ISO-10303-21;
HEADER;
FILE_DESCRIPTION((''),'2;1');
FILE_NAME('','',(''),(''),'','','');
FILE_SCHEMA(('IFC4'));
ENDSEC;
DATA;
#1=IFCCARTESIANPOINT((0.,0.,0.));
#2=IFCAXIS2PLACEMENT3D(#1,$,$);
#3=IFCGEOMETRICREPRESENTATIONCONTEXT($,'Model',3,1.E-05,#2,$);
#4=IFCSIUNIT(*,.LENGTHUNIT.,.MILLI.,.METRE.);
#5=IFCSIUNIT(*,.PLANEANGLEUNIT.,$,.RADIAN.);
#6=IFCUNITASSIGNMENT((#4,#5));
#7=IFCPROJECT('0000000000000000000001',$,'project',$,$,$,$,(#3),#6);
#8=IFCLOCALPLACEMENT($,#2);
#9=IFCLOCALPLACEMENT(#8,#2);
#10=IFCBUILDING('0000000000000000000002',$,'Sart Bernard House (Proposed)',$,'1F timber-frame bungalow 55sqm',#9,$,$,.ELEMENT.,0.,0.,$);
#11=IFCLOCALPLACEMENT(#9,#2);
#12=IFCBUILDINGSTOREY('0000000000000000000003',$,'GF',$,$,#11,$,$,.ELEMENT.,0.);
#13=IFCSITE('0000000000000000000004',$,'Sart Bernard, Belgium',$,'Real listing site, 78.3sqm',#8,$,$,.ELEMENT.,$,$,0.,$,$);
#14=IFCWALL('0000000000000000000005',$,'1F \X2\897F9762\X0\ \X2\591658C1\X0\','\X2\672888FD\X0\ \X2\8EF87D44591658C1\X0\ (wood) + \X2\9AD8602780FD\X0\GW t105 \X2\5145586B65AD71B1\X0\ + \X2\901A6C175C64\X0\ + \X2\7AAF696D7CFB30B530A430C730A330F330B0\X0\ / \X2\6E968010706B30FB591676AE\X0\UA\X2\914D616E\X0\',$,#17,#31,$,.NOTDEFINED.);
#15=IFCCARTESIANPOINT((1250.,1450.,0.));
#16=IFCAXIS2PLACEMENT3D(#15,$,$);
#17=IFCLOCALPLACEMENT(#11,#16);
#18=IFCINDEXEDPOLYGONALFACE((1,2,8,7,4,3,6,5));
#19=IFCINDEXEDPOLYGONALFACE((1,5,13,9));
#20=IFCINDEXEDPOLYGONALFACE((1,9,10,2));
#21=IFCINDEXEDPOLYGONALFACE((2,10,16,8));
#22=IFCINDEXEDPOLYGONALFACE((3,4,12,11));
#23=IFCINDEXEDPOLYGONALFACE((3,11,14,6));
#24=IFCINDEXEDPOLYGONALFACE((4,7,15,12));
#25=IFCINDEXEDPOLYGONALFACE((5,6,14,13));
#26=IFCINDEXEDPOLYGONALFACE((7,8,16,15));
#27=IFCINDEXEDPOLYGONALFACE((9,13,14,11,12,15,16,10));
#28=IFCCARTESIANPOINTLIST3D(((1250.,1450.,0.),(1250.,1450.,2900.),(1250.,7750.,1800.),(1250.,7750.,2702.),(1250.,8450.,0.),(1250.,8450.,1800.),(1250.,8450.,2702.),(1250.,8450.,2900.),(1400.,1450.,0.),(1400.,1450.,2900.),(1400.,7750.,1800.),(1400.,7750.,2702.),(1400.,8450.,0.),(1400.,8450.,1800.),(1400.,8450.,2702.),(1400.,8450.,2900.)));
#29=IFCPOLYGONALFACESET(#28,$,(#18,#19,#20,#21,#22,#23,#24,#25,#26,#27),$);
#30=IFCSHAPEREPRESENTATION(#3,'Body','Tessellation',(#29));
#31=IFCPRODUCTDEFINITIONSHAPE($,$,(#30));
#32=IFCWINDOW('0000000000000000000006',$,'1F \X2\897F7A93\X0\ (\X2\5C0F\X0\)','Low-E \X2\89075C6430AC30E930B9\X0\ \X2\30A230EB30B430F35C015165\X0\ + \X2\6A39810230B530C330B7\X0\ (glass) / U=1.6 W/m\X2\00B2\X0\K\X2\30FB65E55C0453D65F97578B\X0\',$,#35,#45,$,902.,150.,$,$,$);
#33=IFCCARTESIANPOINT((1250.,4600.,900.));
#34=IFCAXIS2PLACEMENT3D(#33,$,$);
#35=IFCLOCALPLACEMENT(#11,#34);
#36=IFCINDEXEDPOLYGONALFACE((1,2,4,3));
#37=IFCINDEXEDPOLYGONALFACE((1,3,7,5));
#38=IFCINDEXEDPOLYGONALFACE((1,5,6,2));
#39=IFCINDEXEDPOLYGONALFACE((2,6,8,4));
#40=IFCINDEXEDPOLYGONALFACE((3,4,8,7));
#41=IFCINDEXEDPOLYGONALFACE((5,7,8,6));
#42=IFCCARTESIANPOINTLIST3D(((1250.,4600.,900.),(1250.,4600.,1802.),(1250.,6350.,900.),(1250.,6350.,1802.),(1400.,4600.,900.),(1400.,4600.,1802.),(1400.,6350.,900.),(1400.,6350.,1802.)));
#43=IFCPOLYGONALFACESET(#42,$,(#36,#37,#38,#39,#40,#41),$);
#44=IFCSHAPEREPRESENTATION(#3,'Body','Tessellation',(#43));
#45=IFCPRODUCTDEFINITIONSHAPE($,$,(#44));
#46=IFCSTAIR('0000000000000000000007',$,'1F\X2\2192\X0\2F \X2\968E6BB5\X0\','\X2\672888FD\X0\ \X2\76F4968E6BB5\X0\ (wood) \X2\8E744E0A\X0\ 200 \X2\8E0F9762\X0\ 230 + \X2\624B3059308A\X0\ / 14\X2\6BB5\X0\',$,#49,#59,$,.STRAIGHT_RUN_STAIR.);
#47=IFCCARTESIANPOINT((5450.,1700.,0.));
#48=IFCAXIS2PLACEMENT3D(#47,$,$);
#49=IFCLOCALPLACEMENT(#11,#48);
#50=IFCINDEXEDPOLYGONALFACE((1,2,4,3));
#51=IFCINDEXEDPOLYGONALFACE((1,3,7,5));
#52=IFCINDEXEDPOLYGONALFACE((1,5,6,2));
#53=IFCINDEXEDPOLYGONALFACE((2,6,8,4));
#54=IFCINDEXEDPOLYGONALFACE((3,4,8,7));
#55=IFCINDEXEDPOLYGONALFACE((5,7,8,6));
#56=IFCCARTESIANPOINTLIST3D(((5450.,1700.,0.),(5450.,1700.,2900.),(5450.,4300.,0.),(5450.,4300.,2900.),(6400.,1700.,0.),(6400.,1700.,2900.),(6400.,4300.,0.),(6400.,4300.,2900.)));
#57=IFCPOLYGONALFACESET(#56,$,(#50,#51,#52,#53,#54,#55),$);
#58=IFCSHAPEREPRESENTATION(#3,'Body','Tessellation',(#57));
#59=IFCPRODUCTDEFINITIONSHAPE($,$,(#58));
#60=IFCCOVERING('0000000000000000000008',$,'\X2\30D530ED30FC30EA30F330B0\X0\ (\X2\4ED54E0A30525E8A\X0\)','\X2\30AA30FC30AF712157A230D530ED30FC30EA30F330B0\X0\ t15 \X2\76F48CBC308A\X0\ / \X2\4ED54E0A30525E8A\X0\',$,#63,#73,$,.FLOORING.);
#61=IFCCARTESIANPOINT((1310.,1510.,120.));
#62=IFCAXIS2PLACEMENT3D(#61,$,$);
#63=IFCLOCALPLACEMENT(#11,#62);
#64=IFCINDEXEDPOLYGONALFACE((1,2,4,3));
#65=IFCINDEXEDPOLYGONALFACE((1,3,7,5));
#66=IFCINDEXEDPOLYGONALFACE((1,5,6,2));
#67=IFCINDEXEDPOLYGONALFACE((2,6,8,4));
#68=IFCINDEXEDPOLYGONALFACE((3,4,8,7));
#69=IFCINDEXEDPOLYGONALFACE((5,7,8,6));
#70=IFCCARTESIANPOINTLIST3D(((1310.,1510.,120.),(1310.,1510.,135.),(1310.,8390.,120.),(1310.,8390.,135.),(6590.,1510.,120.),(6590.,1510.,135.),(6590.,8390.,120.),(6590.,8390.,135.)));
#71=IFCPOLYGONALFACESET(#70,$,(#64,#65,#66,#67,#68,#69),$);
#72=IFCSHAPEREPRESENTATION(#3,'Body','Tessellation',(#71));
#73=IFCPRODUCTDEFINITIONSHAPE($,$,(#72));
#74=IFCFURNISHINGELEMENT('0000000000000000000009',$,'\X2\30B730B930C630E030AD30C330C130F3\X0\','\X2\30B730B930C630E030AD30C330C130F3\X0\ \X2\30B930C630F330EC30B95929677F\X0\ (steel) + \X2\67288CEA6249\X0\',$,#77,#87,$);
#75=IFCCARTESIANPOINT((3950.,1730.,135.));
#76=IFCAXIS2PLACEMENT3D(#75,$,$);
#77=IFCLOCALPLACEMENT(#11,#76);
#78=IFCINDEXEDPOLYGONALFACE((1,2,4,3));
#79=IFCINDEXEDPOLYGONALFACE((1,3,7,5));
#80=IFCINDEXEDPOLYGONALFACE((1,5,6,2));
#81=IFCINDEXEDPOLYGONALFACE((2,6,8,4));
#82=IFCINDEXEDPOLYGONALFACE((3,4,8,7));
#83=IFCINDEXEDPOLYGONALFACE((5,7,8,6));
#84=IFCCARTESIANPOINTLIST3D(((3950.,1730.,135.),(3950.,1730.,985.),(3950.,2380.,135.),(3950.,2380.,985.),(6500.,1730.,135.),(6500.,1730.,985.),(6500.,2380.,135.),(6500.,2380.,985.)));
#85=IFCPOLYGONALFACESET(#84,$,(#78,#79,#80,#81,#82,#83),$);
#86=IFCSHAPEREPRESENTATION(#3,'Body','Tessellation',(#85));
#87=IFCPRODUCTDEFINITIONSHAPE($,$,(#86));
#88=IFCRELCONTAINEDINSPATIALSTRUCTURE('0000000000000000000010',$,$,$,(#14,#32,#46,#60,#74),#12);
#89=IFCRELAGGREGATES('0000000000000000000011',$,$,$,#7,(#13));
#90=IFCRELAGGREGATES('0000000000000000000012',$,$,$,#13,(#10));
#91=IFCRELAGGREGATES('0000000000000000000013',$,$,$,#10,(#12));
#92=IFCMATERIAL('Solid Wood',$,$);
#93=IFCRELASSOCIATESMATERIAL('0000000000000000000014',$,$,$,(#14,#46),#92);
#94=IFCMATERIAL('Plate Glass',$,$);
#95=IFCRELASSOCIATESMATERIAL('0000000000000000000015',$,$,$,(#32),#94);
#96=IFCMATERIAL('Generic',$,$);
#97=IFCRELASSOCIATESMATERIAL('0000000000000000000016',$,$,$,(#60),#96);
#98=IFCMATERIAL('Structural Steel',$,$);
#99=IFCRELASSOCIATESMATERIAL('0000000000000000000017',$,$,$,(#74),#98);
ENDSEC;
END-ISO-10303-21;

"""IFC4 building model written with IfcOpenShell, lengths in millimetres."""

from ifc_helpers import new_model, si_unit, frame, frame_2d, origin, place, context, project, spatial, rectangle, extrude, material, element, fill, save


model = new_model("IFC4")

# Units and contexts
model_context = context("Model", 3, precision=1e-05, world=origin())
ifc_project = project(units=[si_unit("LENGTHUNIT", "METRE", prefix="MILLI"), si_unit("PLANEANGLEUNIT", "RADIAN")], contexts=[model_context])

# Site, building, storey
site_placement = place(None, origin())
site = spatial("IfcSite", under=ifc_project, at=site_placement, Name="Sart Bernard, Belgium", ObjectType="Real listing site, 78.3sqm", CompositionType="ELEMENT", RefElevation=0.0)
building_placement = place(site_placement, origin())
building = spatial("IfcBuilding", under=site, at=building_placement, Name="Sart Bernard House (Proposed)", ObjectType="1F timber-frame bungalow 55sqm", CompositionType="ELEMENT", ElevationOfRefHeight=0.0, ElevationOfTerrain=0.0)
storey_placement = place(building_placement, origin())
storey = spatial("IfcBuildingStorey", under=building, at=storey_placement, Name="GF", CompositionType="ELEMENT", Elevation=0.0)

# Shared definitions
ifc_material_1 = material(Name="Solid Wood")
ifc_material_2 = material(Name="Generic")

# Shared definitions
ifc_material_3 = material(Name="Plate Glass")

# Wall, opening, window
wall_1_placement = place(storey_placement, frame((1250.0, 1450.0, 0.0)))
wall_1 = element("IfcWall", 1, at=wall_1_placement, inside=storey, material=ifc_material_1, Name="1F 西面 外壁", Description="木製 軸組外壁 (wood) + 高性能GW t105 充填断熱 + 通気層 + 窯業系サイディング / 準耐火・外皮UA配慮", PredefinedType="NOTDEFINED", context=model_context, shape_type="SweptSolid", body=[
    extrude(rectangle(XDim=150.0, YDim=7000.0, at=frame_2d((75.0, 3500.0))), frame((1250.0, 1450.0, 0.0)), (0.0, 0.0, 1.0), 2900.0),
])
opening_1_placement = place(storey_placement, frame((1250.0, 4600.0, 900.0)))
opening_1 = element("IfcOpeningElement", 2, at=opening_1_placement, cuts=wall_1, PredefinedType="NOTDEFINED", context=model_context, shape_type="SweptSolid", body=[
    extrude(rectangle(XDim=150.0, YDim=1750.0, at=frame_2d((75.0, 875.0))), frame((1250.0, 4600.0, 900.0)), (0.0, 0.0, 1.0), 902.0),
])
window_1_placement = place(storey_placement, frame((1250.0, 4600.0, 900.0)))
window_1 = element("IfcWindow", 3, at=window_1_placement, inside=storey, material=ifc_material_3, Name="1F 西窓 (小)", Description="Low-E 複層ガラス アルゴン封入 + 樹脂サッシ (glass) / U=1.6 W/m²K・日射取得型", OverallHeight=902.0, OverallWidth=150.0, context=model_context, shape_type="SweptSolid", body=[
    extrude(rectangle(XDim=150.0, YDim=1750.0, at=frame_2d((75.0, 875.0))), frame((1250.0, 4600.0, 900.0)), (0.0, 0.0, 1.0), 902.0),
])
fill(opening_1, window_1)

# Stair
stair_placement = place(storey_placement, frame((5450.0, 1700.0, 0.0)))
element("IfcStair", 4, at=stair_placement, inside=storey, material=ifc_material_1, Name="1F→2F 階段", Description="木製 直階段 (wood) 蹴上 200 踏面 230 + 手すり / 14段", PredefinedType="STRAIGHT_RUN_STAIR", context=model_context, shape_type="SweptSolid", body=[
    extrude(rectangle(XDim=950.0, YDim=2600.0, at=frame_2d((475.0, 1300.0))), frame((5450.0, 1700.0, 0.0)), (0.0, 0.0, 1.0), 2900.0),
])

# Covering
covering_placement = place(storey_placement, frame((1310.0, 1510.0, 120.0)))
element("IfcCovering", 5, at=covering_placement, inside=storey, material=ifc_material_2, Name="フローリング (仕上げ床)", Description="オーク無垢フローリング t15 直貼り / 仕上げ床", PredefinedType="FLOORING", context=model_context, shape_type="SweptSolid", body=[
    extrude(rectangle(XDim=5280.0, YDim=6880.0, at=frame_2d((2640.0, 3440.0))), frame((1310.0, 1510.0, 120.0)), (0.0, 0.0, 1.0), 15.0),
])

# Furnishing element
ifc_material_4 = material(Name="Structural Steel")
furnishing_placement = place(storey_placement, frame((3950.0, 1730.0, 135.0)))
element("IfcFurnishingElement", 6, at=furnishing_placement, inside=storey, material=ifc_material_4, Name="システムキッチン", Description="システムキッチン ステンレス天板 (steel) + 木質扉", context=model_context, shape_type="SweptSolid", body=[
    extrude(rectangle(XDim=2550.0, YDim=650.0, at=frame_2d((1275.0, 325.0))), frame((3950.0, 1730.0, 135.0)), (0.0, 0.0, 1.0), 850.0),
])

save(model, "model.ifc")
